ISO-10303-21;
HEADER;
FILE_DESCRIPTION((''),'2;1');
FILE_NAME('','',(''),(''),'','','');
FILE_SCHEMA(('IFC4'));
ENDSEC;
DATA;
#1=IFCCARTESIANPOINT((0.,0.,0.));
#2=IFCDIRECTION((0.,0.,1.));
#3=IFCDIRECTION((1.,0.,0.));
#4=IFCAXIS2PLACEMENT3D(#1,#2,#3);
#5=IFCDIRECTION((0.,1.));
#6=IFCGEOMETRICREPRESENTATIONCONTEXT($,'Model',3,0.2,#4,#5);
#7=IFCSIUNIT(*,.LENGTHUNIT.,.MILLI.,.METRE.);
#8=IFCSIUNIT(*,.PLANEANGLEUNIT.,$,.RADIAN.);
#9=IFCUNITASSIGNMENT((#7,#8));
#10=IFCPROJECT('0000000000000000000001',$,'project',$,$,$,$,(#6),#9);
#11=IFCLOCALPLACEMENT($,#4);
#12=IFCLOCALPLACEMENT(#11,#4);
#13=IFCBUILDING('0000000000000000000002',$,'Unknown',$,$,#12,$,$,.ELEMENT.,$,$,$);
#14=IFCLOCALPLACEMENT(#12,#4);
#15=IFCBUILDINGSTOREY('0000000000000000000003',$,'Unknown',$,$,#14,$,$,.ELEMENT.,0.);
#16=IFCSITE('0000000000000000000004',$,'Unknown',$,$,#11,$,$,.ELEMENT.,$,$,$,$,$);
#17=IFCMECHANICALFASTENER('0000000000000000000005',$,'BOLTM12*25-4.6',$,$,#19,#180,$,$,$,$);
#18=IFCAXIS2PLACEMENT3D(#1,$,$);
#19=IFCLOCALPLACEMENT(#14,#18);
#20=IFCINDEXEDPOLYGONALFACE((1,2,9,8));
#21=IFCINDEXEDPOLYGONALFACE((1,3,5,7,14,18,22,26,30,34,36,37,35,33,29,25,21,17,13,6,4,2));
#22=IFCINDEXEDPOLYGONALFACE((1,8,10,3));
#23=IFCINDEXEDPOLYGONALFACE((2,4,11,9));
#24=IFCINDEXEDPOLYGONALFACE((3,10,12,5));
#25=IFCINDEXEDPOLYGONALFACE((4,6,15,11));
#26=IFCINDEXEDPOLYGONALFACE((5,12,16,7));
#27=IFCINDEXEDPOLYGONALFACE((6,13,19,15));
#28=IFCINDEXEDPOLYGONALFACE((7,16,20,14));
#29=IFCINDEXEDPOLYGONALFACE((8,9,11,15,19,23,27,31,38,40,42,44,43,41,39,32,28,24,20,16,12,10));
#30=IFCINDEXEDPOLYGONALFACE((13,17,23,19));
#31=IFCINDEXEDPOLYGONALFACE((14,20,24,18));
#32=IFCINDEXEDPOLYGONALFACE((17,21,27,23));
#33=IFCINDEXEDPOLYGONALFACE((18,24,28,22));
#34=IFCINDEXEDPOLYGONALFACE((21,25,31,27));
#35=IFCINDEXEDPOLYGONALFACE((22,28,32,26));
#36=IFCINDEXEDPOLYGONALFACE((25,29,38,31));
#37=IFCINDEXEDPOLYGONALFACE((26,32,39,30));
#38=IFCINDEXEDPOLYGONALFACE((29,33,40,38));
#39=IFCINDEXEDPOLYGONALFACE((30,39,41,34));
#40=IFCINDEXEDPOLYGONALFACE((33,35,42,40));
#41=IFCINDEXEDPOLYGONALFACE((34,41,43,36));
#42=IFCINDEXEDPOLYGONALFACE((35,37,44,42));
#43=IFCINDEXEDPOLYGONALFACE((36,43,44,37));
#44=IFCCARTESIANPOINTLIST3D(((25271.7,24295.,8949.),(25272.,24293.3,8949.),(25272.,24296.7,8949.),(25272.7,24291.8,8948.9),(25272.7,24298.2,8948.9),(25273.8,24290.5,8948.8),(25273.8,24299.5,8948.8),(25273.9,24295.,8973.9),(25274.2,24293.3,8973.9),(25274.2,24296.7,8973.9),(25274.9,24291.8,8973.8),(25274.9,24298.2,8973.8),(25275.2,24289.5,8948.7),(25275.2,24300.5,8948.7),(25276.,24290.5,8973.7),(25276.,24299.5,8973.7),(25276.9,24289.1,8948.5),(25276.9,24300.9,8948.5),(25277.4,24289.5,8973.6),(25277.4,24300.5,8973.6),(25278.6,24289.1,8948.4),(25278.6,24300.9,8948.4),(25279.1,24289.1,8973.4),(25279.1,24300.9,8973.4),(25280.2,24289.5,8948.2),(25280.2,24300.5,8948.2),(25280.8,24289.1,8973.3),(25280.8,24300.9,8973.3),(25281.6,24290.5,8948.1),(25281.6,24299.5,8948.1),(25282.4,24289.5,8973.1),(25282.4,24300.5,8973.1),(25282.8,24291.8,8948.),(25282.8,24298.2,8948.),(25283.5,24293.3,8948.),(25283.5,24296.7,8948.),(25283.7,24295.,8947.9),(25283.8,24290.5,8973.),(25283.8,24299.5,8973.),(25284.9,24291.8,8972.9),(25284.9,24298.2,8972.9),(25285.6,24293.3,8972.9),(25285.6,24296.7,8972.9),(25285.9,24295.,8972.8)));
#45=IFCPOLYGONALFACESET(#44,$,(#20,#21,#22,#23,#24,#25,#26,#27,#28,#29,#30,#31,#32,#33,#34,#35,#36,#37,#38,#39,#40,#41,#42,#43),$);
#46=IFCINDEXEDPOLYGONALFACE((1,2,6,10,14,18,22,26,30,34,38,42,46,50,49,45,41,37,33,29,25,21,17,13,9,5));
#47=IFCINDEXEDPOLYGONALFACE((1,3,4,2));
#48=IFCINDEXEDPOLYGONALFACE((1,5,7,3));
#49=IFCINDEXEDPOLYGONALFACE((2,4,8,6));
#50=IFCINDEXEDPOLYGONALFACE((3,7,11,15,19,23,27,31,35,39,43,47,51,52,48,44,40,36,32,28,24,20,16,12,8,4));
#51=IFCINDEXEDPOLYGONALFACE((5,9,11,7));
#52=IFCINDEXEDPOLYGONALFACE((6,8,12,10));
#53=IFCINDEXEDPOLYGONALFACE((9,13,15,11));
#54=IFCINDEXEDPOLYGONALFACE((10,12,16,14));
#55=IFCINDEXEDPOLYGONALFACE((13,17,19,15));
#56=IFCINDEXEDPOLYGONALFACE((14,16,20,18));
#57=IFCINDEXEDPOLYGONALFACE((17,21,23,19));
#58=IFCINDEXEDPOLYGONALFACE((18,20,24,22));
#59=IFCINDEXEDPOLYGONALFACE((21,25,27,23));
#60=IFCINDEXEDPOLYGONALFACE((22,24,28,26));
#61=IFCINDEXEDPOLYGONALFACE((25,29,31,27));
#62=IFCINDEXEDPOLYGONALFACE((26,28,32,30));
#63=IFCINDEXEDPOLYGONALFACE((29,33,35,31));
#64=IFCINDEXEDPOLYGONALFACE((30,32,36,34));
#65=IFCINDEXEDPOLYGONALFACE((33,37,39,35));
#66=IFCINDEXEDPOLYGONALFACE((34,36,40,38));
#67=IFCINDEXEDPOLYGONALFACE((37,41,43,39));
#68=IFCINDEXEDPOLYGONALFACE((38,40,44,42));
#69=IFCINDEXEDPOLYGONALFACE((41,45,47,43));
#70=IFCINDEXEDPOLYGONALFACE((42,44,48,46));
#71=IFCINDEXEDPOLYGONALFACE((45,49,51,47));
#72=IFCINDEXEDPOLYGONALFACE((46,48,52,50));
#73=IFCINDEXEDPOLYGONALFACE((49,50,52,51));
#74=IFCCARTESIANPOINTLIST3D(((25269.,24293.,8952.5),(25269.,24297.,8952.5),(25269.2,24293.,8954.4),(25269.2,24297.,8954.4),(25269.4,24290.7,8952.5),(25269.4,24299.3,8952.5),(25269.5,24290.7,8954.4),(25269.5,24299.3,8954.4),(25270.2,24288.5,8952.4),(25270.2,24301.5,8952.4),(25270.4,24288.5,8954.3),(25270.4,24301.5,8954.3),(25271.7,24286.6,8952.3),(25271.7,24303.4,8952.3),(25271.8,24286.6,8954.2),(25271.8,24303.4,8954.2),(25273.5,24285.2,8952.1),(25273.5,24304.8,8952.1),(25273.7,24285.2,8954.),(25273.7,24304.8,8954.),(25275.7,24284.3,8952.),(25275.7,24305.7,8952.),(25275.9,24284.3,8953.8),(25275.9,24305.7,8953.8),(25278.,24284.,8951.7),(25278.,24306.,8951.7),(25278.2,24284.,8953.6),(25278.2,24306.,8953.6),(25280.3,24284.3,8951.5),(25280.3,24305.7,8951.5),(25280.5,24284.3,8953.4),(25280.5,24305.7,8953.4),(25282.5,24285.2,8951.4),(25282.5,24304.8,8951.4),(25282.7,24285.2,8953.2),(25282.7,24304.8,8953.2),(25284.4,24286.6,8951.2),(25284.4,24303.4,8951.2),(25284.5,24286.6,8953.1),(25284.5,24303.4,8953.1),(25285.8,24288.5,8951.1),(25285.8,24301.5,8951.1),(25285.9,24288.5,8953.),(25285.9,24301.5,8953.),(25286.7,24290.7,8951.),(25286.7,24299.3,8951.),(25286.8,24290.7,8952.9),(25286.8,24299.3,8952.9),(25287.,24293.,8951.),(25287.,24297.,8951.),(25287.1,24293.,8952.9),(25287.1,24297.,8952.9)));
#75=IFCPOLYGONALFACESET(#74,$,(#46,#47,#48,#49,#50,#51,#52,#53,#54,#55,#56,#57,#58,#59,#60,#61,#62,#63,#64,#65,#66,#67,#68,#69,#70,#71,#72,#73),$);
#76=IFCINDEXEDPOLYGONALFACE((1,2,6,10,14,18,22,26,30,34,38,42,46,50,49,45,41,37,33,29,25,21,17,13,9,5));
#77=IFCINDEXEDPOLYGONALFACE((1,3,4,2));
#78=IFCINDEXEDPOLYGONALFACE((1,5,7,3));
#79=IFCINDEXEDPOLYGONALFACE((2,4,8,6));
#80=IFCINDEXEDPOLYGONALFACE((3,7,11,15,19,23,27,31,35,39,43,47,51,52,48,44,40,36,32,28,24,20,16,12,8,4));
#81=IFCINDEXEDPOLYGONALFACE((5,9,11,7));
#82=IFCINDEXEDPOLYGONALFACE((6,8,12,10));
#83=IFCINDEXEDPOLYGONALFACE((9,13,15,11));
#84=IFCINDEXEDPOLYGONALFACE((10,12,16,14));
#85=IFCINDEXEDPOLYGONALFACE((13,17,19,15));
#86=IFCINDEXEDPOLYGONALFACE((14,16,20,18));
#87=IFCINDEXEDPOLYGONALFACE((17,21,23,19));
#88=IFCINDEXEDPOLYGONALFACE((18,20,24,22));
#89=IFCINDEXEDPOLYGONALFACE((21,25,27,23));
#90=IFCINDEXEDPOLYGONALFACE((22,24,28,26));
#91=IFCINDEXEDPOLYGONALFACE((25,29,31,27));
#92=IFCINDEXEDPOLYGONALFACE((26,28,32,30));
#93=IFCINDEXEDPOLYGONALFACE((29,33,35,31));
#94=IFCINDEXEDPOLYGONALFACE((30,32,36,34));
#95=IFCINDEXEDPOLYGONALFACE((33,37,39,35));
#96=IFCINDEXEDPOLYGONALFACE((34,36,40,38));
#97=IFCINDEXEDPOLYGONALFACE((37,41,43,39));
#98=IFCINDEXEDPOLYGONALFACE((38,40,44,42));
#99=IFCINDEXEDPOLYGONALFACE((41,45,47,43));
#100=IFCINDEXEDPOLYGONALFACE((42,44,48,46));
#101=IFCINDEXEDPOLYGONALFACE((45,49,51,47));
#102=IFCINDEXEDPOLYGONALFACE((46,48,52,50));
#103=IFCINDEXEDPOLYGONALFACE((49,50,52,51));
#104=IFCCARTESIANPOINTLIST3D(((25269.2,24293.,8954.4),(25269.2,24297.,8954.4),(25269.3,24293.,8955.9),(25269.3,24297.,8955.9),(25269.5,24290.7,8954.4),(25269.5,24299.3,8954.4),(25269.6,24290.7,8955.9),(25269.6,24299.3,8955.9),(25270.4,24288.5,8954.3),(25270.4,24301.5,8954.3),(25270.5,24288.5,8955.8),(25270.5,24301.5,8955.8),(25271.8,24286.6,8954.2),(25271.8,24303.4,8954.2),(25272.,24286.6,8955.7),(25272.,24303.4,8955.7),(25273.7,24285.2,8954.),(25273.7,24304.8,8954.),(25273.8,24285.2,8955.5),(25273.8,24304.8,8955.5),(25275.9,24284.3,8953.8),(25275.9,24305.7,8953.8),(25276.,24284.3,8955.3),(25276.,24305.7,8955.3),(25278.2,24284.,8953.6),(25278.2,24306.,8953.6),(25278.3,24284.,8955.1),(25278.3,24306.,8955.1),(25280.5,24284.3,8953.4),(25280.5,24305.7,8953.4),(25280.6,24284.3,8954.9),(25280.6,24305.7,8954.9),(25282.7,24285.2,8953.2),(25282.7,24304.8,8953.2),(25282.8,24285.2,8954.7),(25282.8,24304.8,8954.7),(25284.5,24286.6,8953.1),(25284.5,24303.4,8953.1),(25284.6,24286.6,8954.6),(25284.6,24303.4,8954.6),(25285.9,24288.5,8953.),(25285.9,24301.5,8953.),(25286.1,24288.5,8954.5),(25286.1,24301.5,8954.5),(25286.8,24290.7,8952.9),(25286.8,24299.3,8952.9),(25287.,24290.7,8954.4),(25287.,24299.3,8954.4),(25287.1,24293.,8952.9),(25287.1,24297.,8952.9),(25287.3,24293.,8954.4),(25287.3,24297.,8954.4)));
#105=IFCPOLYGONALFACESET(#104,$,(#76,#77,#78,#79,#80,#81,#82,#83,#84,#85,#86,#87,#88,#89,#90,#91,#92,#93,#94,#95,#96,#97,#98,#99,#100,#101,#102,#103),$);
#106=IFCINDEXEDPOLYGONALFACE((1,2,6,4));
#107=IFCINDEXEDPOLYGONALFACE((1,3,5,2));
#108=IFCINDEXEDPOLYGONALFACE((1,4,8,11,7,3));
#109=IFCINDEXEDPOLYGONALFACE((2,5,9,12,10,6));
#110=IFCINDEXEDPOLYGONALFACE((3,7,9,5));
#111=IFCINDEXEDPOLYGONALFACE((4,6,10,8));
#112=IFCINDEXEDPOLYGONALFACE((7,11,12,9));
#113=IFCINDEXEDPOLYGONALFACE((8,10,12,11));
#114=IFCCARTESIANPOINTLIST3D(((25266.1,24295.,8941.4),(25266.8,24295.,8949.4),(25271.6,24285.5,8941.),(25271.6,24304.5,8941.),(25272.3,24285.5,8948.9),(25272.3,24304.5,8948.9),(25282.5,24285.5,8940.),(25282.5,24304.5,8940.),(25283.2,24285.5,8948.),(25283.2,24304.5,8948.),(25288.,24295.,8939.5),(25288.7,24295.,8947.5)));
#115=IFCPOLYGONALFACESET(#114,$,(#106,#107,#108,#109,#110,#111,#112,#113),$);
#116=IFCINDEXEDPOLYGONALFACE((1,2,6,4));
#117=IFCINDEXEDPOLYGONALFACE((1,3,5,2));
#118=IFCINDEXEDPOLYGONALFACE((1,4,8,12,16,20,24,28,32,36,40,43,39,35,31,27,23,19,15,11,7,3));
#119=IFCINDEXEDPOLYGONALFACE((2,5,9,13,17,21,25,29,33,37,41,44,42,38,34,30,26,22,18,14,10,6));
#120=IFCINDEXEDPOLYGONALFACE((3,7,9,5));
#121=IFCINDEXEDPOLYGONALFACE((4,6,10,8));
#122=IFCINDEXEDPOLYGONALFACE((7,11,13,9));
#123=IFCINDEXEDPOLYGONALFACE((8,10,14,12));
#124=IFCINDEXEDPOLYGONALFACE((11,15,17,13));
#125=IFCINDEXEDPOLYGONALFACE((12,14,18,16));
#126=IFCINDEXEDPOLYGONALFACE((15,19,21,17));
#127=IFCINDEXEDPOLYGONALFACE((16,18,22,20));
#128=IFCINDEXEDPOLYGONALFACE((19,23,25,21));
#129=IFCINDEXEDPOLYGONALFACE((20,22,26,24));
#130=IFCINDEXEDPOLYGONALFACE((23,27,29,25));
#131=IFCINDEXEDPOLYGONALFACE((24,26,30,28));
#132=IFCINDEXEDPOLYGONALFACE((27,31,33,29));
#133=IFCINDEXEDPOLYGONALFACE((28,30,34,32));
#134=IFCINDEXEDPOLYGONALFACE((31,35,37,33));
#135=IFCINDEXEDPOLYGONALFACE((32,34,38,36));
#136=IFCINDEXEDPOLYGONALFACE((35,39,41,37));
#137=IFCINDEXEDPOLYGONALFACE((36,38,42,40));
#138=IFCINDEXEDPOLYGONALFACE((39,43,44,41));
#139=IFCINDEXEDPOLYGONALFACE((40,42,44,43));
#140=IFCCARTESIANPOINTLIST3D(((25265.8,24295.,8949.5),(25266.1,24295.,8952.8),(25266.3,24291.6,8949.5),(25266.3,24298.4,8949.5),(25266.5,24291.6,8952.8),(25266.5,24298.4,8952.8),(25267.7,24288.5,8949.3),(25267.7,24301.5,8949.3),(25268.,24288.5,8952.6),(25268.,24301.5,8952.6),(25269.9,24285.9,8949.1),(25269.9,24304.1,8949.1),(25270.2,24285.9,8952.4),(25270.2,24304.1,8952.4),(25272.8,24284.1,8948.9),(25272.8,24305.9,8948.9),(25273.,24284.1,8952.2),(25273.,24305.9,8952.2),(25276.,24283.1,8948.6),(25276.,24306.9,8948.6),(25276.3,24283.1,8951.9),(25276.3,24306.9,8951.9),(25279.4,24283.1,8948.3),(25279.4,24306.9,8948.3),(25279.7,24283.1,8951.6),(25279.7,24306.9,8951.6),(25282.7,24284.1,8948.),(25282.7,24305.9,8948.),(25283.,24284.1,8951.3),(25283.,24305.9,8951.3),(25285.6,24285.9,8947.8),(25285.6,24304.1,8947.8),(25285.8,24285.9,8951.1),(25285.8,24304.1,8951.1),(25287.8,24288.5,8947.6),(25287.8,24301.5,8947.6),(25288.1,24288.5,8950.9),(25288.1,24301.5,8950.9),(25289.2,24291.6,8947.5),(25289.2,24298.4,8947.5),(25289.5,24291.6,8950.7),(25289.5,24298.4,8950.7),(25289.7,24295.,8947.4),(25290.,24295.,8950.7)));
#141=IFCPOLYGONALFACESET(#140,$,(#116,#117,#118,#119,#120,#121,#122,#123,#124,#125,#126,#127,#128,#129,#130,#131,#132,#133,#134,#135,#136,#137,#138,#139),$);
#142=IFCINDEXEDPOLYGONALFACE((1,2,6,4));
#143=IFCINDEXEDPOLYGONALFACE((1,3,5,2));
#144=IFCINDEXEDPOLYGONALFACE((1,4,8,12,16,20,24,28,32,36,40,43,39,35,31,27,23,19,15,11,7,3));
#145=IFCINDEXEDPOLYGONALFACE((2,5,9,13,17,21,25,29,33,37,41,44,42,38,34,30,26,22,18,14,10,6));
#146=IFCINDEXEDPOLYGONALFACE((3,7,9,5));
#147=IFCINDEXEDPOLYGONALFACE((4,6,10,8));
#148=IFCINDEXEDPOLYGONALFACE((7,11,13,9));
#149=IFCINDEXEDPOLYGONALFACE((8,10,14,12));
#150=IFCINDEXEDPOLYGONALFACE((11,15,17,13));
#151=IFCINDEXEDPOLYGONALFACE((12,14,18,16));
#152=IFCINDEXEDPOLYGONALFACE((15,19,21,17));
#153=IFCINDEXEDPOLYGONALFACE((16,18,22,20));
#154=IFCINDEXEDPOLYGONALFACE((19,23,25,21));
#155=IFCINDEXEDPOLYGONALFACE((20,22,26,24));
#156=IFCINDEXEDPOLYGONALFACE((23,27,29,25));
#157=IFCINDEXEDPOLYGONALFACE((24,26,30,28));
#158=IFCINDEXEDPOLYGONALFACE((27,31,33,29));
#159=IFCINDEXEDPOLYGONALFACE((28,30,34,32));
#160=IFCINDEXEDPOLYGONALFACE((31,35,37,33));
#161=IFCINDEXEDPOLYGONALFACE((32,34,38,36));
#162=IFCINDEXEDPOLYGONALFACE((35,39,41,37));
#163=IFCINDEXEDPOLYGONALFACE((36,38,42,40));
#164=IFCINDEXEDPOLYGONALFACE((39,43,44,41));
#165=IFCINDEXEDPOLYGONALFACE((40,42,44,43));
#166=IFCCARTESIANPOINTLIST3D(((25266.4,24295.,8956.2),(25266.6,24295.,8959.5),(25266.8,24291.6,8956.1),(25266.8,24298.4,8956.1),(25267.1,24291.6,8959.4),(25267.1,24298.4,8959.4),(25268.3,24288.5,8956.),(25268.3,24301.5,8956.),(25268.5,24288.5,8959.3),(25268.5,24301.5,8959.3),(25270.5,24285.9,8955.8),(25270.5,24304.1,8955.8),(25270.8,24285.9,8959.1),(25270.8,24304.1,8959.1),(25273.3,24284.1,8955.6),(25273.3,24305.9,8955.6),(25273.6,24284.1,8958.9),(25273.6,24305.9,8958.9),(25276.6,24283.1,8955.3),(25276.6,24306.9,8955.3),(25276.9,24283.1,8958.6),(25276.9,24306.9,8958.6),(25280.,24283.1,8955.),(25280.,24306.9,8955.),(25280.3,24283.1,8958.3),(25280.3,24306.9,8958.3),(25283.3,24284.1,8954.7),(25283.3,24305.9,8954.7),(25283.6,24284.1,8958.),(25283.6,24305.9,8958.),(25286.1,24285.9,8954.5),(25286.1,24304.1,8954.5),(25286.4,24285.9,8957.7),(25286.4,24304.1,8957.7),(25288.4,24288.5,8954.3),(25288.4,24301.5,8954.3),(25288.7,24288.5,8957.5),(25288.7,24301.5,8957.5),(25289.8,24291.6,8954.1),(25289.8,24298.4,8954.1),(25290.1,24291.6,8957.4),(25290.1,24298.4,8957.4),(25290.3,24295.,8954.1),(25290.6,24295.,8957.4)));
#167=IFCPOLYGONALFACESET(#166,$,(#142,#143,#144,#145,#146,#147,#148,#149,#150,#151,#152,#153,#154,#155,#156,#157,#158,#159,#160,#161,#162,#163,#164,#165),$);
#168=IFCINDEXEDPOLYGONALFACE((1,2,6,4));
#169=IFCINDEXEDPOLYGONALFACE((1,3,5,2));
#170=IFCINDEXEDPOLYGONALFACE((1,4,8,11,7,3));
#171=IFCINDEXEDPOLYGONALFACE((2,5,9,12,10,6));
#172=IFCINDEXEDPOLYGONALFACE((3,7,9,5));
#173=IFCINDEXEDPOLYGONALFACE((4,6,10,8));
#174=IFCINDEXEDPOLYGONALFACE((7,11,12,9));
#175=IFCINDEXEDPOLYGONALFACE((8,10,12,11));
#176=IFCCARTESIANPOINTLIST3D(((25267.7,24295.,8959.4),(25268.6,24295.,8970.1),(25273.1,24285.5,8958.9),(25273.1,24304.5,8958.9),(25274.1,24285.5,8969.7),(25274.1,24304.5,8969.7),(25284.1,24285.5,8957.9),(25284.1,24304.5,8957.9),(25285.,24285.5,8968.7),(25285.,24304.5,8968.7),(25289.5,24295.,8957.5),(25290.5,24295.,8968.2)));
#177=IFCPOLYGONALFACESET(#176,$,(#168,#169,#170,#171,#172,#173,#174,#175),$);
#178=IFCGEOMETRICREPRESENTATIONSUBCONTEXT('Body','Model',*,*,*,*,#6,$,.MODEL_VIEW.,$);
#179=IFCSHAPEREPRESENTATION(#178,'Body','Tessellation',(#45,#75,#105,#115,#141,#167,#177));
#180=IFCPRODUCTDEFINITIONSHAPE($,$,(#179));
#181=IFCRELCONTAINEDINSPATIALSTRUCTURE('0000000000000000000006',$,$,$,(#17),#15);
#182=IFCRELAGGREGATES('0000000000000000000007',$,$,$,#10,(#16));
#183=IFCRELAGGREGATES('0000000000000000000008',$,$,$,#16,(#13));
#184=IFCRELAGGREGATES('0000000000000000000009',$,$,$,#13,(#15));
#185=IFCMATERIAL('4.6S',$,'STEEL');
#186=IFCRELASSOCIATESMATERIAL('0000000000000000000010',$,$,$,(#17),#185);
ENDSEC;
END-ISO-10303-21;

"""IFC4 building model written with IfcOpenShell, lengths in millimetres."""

from ifc_helpers import new_model, si_unit, direction, frame, origin_with_axes, place, context, subcontext, project, spatial, line, arc, indexed_curve, outline, extrude, source, transform, mapped, material, element, save


model = new_model("IFC4")

# Units and contexts
model_context = context("Model", 3, precision=0.2, world=origin_with_axes(), true_north=direction((0.0, 1.0)))
body_context = subcontext(model_context, "Body", "Model", "MODEL_VIEW")
ifc_project = project(units=[si_unit("LENGTHUNIT", "METRE", prefix="MILLI"), si_unit("PLANEANGLEUNIT", "RADIAN")], contexts=[model_context])

# Site, building, storey
site_placement = place(None, origin_with_axes())
site = spatial("IfcSite", under=ifc_project, at=site_placement, Name="Unknown", CompositionType="ELEMENT")
building_placement = place(site_placement, origin_with_axes())
building = spatial("IfcBuilding", under=site, at=building_placement, Name="Unknown", CompositionType="ELEMENT")
storey_placement = place(building_placement, origin_with_axes())
storey = spatial("IfcBuildingStorey", under=building, at=storey_placement, Name="Unknown", CompositionType="ELEMENT", Elevation=0.0)

# Mechanical fastener
ifc_material_1 = material(Name="4.6S", Category="STEEL")
shared_shape_1 = source(origin_with_axes(), body_context, "Body", "SweptSolid", [
    extrude(outline(indexed_curve([(6.0, 0.0), (0.0, 6.0), (-6.0, 0.0), (0.0, -6.0)], segments=[arc(1, 2, 3), arc(3, 4, 1)])), frame((0.0, 0.0, 4.8), z_axis=(0.0, 0.0, -1.0), x_axis=(0.0, 1.0, 0.0)), (0.0, 0.0, 1.0), 25.0),
    extrude(outline(indexed_curve([(0.0, 11.0), (6.4, 8.4), (9.0, 2.0), (9.0, -2.0), (6.4, -8.4), (0.0, -11.0), (-0.8, -11.0), (-9.0, -2.0), (-9.0, 2.0), (-6.4, 8.4)], segments=[arc(1, 2, 3), line(3, 4), arc(4, 5, 6), arc(6, 7, 8), line(8, 9), arc(9, 10, 1)])), frame((0.0, 0.0, 1.5), z_axis=(0.0, 0.0, -1.0), x_axis=(0.0, 1.0, 0.0)), (0.0, 0.0, 1.0), 1.9),
    extrude(outline(indexed_curve([(0.0, 11.0), (6.4, 8.4), (9.0, 2.0), (9.0, -2.0), (6.4, -8.4), (0.0, -11.0), (-0.8, -11.0), (-9.0, -2.0), (-9.0, 2.0), (-6.4, 8.4)], segments=[arc(1, 2, 3), line(3, 4), arc(4, 5, 6), arc(6, 7, 8), line(8, 9), arc(9, 10, 1)])), frame((0.0, 0.0, -0.4), z_axis=(0.0, 0.0, -1.0), x_axis=(0.0, 1.0, 0.0)), (0.0, 0.0, 1.0), 1.5),
    extrude(outline(indexed_curve([(11.0, 0.0), (5.5, 9.5), (-5.5, 9.5), (-11.0, 0.0), (-5.5, -9.5), (5.5, -9.5)], segments=[line(1, 2, 3, 4, 5, 6, 1)])), frame((0.0, 0.0, 12.8), z_axis=(0.0, 0.0, -1.0), x_axis=(0.0, 1.0, 0.0)), (0.0, 0.0, 1.0), 8.0),
    extrude(outline(indexed_curve([(12.0, 0.0), (0.0, 12.0), (-12.0, 0.0), (0.0, -12.0)], segments=[arc(1, 2, 3), arc(3, 4, 1)])), frame((0.0, 0.0, 4.8), z_axis=(0.0, 0.0, -1.0), x_axis=(0.0, 1.0, 0.0)), (0.0, 0.0, 1.0), 3.3),
    extrude(outline(indexed_curve([(12.0, 0.0), (0.0, 12.0), (-12.0, 0.0), (0.0, -12.0)], segments=[arc(1, 2, 3), arc(3, 4, 1)])), frame((0.0, 0.0, -1.9), z_axis=(0.0, 0.0, -1.0), x_axis=(0.0, 1.0, 0.0)), (0.0, 0.0, 1.0), 3.3),
    extrude(outline(indexed_curve([(11.0, 0.0), (5.5, 9.5), (-5.5, 9.5), (-11.0, 0.0), (-5.5, -9.5), (5.5, -9.5)], segments=[line(1, 2, 3, 4, 5, 6, 1)])), frame((0.0, 0.0, -5.2), z_axis=(0.0, 0.0, -1.0), x_axis=(0.0, 1.0, 0.0)), (0.0, 0.0, 1.0), 10.8),
])
for number, where, z_axis, x_axis, name in (
    (1, (25278.1, 24295.0, 8953.2), (-0.08716, 0.0, -0.996194), (0.0, 1.0, 0.0), "BOLTM12*25-4.6"),
):
    element("IfcMechanicalFastener", number, at=place(storey_placement, frame(where, z_axis=z_axis, x_axis=x_axis)), inside=storey, material=ifc_material_1, Name=name, context=body_context, shape_type="MappedRepresentation", body=[
        mapped(shared_shape_1, transform((0.0, 0.0, 0.0))),
    ])

save(model, "model.ifc")
